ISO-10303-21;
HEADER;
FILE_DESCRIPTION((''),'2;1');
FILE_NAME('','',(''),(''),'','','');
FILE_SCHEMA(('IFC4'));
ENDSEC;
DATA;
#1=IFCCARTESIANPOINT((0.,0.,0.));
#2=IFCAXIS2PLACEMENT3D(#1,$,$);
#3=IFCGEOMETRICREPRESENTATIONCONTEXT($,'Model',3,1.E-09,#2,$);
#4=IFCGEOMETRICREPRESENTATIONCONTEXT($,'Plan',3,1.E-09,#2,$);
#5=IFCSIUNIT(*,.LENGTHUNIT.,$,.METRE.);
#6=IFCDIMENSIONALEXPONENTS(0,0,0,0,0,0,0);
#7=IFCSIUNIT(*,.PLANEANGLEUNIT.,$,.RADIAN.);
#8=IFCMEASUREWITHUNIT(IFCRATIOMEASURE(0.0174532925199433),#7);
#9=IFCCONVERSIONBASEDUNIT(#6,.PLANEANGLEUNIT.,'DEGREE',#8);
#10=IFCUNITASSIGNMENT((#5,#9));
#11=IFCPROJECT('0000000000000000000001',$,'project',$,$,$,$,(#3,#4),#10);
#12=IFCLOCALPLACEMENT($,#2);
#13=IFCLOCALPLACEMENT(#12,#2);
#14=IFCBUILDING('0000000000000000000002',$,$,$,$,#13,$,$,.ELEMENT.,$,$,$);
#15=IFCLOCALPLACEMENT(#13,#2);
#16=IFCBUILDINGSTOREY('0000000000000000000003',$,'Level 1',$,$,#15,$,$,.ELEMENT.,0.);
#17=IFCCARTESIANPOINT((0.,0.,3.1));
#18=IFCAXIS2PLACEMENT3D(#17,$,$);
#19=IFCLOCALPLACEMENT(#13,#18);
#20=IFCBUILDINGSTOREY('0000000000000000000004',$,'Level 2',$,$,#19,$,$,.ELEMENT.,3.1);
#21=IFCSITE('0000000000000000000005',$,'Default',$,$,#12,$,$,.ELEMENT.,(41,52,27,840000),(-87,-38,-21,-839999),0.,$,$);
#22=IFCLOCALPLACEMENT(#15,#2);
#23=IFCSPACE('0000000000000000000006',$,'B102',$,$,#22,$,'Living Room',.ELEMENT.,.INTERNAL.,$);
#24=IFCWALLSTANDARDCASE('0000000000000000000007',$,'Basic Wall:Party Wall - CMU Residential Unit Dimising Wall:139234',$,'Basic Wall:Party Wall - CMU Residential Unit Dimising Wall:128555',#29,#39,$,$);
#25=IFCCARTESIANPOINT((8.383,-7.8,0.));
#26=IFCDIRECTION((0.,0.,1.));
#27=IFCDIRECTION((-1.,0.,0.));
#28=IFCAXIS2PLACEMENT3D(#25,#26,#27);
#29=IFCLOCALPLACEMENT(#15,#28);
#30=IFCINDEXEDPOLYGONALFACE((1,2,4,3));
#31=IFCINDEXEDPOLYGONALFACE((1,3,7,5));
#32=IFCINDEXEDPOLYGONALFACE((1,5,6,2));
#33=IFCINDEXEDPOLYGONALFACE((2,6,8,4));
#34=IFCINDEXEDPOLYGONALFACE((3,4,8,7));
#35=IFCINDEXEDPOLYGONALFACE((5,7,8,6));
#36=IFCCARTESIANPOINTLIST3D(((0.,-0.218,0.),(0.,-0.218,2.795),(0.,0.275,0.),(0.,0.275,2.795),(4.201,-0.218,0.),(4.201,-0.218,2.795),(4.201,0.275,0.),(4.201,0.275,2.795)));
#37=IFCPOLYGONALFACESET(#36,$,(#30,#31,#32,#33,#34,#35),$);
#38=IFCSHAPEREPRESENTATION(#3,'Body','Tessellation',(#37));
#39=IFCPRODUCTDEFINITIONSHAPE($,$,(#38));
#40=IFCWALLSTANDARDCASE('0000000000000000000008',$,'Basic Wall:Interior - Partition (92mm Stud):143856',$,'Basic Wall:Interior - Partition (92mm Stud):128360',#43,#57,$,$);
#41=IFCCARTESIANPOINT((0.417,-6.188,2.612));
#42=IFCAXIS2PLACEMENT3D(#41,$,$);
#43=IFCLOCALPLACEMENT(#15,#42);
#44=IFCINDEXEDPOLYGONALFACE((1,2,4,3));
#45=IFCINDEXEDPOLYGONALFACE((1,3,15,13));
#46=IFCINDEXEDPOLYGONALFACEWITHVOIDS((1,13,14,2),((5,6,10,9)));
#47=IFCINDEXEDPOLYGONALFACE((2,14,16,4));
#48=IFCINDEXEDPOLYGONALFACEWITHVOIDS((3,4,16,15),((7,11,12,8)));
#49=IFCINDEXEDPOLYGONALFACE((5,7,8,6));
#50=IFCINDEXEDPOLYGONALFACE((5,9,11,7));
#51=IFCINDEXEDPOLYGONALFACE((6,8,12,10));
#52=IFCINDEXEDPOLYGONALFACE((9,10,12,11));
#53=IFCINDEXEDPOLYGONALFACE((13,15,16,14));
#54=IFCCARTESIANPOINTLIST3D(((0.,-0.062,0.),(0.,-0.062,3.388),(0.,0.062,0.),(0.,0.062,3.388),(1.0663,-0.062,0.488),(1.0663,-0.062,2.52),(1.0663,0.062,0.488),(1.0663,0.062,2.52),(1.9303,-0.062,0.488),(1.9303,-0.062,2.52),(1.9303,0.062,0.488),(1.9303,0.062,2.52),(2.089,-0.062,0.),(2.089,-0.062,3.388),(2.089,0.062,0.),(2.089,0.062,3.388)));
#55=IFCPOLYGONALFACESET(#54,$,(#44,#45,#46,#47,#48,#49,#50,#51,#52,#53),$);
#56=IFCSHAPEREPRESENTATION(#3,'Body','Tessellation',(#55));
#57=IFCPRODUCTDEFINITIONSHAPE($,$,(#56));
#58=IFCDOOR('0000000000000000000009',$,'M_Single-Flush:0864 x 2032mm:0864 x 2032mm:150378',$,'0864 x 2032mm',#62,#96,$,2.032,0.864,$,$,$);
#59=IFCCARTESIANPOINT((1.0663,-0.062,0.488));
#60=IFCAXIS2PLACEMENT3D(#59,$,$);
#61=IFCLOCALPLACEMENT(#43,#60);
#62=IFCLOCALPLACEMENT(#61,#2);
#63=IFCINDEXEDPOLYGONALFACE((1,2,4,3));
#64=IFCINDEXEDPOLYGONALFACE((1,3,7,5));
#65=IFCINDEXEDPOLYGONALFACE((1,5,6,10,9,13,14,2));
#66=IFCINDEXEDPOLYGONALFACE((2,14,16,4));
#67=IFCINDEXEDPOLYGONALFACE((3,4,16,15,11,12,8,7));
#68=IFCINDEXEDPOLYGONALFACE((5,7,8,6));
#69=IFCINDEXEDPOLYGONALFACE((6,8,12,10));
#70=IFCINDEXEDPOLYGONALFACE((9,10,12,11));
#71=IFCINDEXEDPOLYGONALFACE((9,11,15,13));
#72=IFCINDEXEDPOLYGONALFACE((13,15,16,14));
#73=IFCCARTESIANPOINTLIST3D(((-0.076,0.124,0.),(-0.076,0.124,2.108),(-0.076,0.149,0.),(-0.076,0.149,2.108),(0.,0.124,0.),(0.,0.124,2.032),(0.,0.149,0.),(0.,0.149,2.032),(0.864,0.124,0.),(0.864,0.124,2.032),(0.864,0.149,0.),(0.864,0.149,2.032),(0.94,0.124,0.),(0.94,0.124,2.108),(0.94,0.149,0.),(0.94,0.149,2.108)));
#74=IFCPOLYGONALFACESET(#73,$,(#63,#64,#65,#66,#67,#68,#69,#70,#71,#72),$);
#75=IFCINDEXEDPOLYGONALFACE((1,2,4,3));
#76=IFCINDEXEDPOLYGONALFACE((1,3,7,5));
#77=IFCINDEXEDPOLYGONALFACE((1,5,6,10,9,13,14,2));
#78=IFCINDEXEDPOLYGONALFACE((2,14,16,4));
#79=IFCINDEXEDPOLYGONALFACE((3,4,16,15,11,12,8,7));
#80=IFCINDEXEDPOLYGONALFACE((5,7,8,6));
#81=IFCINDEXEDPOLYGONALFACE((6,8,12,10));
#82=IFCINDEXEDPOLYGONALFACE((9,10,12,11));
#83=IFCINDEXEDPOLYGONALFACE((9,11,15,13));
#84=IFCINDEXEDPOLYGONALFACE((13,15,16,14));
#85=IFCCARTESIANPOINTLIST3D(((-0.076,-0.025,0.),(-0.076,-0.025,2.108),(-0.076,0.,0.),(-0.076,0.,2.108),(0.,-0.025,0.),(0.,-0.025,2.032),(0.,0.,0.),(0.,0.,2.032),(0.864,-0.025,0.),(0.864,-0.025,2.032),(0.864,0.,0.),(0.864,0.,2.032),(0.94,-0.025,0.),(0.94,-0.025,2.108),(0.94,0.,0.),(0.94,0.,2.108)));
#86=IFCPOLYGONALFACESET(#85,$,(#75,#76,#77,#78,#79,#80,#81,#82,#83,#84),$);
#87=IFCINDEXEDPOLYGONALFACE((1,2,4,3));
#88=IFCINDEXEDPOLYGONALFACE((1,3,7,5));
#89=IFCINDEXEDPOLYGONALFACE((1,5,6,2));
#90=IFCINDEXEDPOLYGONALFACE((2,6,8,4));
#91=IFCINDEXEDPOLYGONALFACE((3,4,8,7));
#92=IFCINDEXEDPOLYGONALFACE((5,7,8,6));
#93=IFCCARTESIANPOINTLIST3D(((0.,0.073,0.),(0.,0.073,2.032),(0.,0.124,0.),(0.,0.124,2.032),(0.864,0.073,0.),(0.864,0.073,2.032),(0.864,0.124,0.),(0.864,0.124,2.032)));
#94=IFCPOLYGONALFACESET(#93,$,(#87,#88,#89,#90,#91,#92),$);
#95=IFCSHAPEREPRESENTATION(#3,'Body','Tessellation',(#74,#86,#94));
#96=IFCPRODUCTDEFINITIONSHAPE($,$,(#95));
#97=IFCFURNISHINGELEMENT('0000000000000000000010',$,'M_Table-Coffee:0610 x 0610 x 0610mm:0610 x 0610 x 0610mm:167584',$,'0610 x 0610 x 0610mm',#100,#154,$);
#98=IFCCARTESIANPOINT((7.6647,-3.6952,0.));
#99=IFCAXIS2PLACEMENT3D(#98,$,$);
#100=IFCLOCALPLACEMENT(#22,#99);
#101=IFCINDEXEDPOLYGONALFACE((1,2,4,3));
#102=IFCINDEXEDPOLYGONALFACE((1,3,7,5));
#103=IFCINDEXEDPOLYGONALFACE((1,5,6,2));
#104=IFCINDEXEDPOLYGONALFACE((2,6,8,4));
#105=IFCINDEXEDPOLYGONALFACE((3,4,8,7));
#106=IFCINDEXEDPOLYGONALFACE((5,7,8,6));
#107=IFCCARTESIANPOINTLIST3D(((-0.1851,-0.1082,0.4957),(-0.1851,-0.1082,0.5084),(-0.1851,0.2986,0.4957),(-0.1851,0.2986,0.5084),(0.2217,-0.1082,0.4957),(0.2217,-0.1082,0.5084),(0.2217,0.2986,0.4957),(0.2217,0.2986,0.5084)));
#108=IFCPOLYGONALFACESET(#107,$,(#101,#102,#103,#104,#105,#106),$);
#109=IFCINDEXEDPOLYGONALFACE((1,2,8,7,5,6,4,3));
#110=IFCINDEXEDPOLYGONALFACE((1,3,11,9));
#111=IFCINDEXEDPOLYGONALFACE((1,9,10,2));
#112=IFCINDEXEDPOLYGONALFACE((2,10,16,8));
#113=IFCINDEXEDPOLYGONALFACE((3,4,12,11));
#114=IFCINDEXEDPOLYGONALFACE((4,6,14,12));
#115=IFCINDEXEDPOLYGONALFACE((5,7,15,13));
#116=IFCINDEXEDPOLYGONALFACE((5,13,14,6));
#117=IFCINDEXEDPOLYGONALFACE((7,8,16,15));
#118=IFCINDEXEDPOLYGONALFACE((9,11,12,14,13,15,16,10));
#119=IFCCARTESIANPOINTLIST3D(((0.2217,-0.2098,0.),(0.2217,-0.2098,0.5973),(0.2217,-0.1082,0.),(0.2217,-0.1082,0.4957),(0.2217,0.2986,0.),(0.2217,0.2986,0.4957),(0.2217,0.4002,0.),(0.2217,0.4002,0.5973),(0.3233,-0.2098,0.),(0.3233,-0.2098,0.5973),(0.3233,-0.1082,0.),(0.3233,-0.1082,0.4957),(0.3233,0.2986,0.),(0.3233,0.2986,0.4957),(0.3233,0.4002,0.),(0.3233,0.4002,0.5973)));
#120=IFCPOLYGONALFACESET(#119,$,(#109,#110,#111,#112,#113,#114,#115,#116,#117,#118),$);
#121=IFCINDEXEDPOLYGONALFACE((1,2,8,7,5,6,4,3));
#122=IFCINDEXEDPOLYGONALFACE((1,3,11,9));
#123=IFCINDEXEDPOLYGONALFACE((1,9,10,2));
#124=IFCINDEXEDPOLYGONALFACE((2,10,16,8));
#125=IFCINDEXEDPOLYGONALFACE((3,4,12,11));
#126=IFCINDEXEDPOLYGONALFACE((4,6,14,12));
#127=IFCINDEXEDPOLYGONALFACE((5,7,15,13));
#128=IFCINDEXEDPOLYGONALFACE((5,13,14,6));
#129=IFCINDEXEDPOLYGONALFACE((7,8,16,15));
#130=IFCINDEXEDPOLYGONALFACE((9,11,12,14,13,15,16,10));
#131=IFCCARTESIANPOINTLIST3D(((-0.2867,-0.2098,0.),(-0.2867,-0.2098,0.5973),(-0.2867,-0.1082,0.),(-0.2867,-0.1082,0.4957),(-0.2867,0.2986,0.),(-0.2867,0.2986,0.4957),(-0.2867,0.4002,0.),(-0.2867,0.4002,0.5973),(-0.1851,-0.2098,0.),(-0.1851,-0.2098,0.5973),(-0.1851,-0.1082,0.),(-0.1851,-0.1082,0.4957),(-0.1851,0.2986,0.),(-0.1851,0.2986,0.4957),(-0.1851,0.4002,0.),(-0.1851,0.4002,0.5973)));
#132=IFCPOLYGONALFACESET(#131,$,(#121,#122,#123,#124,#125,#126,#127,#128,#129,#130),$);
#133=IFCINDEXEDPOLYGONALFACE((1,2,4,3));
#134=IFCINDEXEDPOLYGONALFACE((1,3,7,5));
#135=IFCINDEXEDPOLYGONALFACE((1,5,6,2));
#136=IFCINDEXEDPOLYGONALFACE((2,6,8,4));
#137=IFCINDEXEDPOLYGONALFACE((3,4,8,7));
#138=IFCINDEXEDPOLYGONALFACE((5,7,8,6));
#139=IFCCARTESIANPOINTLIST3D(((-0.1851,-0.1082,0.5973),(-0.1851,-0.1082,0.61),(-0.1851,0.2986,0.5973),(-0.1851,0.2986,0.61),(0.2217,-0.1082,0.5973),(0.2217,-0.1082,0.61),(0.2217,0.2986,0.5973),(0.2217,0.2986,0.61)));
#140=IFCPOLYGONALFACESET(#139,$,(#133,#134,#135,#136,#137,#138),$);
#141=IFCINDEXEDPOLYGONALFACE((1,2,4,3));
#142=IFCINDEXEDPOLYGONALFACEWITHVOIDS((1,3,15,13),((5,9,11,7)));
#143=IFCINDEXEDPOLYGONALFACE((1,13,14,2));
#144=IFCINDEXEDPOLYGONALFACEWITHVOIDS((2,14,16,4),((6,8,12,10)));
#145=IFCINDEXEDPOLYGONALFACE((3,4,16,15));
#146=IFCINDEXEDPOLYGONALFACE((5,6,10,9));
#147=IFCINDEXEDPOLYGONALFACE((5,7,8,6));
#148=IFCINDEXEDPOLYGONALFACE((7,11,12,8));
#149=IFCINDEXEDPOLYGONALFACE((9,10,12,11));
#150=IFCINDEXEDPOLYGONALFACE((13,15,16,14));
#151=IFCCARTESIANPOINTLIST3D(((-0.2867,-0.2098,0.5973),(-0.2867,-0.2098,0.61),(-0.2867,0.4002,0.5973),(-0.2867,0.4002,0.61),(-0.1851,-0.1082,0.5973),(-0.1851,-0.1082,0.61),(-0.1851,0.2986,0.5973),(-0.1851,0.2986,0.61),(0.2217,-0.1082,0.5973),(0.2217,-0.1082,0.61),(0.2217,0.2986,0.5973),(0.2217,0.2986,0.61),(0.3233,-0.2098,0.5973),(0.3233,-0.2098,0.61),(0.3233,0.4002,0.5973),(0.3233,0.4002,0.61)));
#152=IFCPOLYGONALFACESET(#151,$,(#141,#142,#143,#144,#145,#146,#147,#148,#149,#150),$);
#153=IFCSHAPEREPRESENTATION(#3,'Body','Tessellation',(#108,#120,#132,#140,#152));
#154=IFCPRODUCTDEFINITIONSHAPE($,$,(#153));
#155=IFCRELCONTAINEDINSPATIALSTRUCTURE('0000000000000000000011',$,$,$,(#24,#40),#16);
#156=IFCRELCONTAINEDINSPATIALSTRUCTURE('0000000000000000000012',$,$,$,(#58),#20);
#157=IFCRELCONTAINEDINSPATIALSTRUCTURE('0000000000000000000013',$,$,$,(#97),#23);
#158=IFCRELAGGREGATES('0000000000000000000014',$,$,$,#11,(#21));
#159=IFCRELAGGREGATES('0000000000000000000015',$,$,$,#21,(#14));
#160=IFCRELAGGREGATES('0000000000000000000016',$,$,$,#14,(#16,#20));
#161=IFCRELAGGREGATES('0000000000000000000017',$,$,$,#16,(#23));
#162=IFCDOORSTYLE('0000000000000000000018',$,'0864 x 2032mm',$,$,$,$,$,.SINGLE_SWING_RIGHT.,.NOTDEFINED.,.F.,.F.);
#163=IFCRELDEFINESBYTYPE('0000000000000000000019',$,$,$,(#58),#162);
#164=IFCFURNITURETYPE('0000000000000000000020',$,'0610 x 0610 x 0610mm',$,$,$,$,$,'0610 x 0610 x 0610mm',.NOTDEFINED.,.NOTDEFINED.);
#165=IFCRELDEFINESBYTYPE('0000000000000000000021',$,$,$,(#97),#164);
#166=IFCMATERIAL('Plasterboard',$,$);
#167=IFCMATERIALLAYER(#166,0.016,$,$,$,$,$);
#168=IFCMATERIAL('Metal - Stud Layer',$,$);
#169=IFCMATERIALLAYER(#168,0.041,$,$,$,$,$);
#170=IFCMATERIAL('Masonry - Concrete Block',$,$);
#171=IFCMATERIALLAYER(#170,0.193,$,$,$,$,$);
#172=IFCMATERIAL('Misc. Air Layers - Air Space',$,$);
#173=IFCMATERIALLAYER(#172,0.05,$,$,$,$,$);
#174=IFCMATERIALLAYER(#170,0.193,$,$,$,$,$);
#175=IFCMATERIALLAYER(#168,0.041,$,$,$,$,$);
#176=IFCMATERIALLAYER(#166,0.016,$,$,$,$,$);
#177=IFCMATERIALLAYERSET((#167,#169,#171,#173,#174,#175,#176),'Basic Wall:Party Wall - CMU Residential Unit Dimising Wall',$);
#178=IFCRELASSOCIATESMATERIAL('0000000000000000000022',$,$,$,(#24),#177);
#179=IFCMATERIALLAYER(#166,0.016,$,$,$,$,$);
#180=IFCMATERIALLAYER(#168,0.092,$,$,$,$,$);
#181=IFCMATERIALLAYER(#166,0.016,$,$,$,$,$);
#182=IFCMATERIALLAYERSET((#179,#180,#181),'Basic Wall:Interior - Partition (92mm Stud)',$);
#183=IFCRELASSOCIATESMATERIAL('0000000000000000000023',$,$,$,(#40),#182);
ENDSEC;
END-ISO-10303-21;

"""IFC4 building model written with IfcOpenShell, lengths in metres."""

from ifc_helpers import new_model, entity, si_unit, converted_unit, frame, frame_2d, origin, origin_2d_with_axis, place, context, project, spatial, polyline, rectangle, outline, extrude, clip, bounded_halfspace, source, transform, mapped, material, layer, layer_set, layer_usage, type_object, type_shapes, element, fill, save


model = new_model("IFC4")

# Units and contexts
model_context = context("Model", 3, precision=1e-09, world=origin())
plan_context = context("Plan", 3, precision=1e-09, world=origin())
ifc_project = project(units=[si_unit("LENGTHUNIT", "METRE"), converted_unit("PLANEANGLEUNIT", "DEGREE", entity("IfcRatioMeasure", 0.0174532925199433), si_unit("PLANEANGLEUNIT", "RADIAN"), dimensions=[0, 0, 0, 0, 0, 0, 0])], contexts=[model_context, plan_context])

# Site, building, storey
site_placement = place(None, origin())
site = spatial("IfcSite", under=ifc_project, at=site_placement, Name="Default", CompositionType="ELEMENT", RefLatitude=(41, 52, 27, 840000), RefLongitude=(-87, -38, -21, -839999), RefElevation=0.0)
building_placement = place(site_placement, origin())
building = spatial("IfcBuilding", under=site, at=building_placement, CompositionType="ELEMENT")
storey_1_placement = place(building_placement, origin())
storey_1 = spatial("IfcBuildingStorey", under=building, at=storey_1_placement, Name="Level 1", CompositionType="ELEMENT", Elevation=0.0)

# Wall
ifc_material_1 = material(Name="Metal - Stud Layer")
ifc_material_2 = material(Name="Plasterboard")
ifc_layer_1 = layer(ifc_material_2, 0.016)
ifc_layer_2 = layer(ifc_material_1, 0.041)
ifc_material_3 = material(Name="Masonry - Concrete Block")
ifc_layer_3 = layer(ifc_material_3, 0.193)
ifc_material_4 = material(Name="Misc. Air Layers - Air Space")
ifc_layer_4 = layer(ifc_material_4, 0.05)
ifc_layer_5 = layer(ifc_material_3, 0.193)
ifc_layer_6 = layer(ifc_material_1, 0.041)
ifc_layer_7 = layer(ifc_material_2, 0.016)
ifc_layer_set_1 = layer_set([ifc_layer_1, ifc_layer_2, ifc_layer_3, ifc_layer_4, ifc_layer_5, ifc_layer_6, ifc_layer_7], Name="Basic Wall:Party Wall - CMU Residential Unit Dimising Wall")
ifc_layer_usage_1 = layer_usage(ifc_layer_set_1, "AXIS2", "NEGATIVE", 0.275)
wall_1_placement = place(storey_1_placement, frame((8.383, -7.8, 0.0), z_axis=(0.0, 0.0, 1.0), x_axis=(-1.0, 0.0, 0.0)))
element("IfcWallStandardCase", 1, at=wall_1_placement, inside=storey_1, material=ifc_layer_usage_1, Name="Basic Wall:Party Wall - CMU Residential Unit Dimising Wall:139234", ObjectType="Basic Wall:Party Wall - CMU Residential Unit Dimising Wall:128555", context=model_context, shape_type="Clipping", body=[
    clip(clip(extrude(rectangle(XDim=4.201, YDim=0.55, at=frame_2d((2.1005, 0.0), x_axis=(-1.0, 0.0))), origin(), (0.0, 0.0, 1.0), 2.795), bounded_halfspace(frame((0.0, -0.218, 2.795), z_axis=(0.0, 1.0, 0.0), x_axis=(-1.0, 0.0, 0.0)), True, frame((0.0, -0.218, 2.795), z_axis=(0.0, 1.0, 0.0), x_axis=(-1.0, 0.0, 0.0)), polyline([(0.0, 0.0), (-3.708, 0.0), (-4.201, 0.0), (-4.201, -2.795), (0.0, -2.795), (0.0, 0.0)]))), bounded_halfspace(frame((4.201, 0.275, 0.0), z_axis=(-1.0, 0.0, 0.0), x_axis=(0.0, -1.0, 0.0)), True, frame((4.201, 0.275, 0.0), z_axis=(-1.0, 0.0, 0.0), x_axis=(0.0, -1.0, 0.0)), polyline([(0.0, 0.0), (0.493, 0.0), (0.493, 2.795), (0.0, 2.795), (0.0, 0.0)]))),
])

# Shared definitions
ifc_layer_8 = layer(ifc_material_2, 0.016)
ifc_layer_9 = layer(ifc_material_1, 0.092)
ifc_layer_10 = layer(ifc_material_2, 0.016)
ifc_layer_set_2 = layer_set([ifc_layer_8, ifc_layer_9, ifc_layer_10], Name="Basic Wall:Interior - Partition (92mm Stud)")

# Wall, opening
ifc_layer_usage_2 = layer_usage(ifc_layer_set_2, "AXIS2", "NEGATIVE", 0.062)
wall_2_placement = place(storey_1_placement, frame((0.417, -6.188, 2.612)))
wall_2 = element("IfcWallStandardCase", 2, at=wall_2_placement, inside=storey_1, material=ifc_layer_usage_2, Name="Basic Wall:Interior - Partition (92mm Stud):143856", ObjectType="Basic Wall:Interior - Partition (92mm Stud):128360", context=model_context, shape_type="SweptSolid", body=[
    extrude(rectangle(XDim=2.089, YDim=0.124, at=frame_2d((1.0445, 0.0), x_axis=(-1.0, 0.0))), origin(), (0.0, 0.0, 1.0), 3.388),
])
opening_1_placement = place(wall_2_placement, frame((1.0663, -0.062, 0.488)))
opening_1 = element("IfcOpeningElement", 3, at=opening_1_placement, cuts=wall_2, ObjectType="Opening", context=model_context, shape_type="SweptSolid", body=[
    extrude(rectangle(XDim=0.864, YDim=2.032, at=frame_2d((1.016, 0.432), x_axis=(0.0, 1.0))), frame((0.0, 0.0, 0.0), z_axis=(0.0, 1.0, 0.0), x_axis=(0.0, 0.0, 1.0)), (0.0, 0.0, 1.0), 0.124),
])

# Shared definitions
storey_2_placement = place(building_placement, frame((0.0, 0.0, 3.1)))
storey_2 = spatial("IfcBuildingStorey", under=building, at=storey_2_placement, Name="Level 2", CompositionType="ELEMENT", Elevation=3.1)

# Door
door_style_1 = type_object("IfcDoorStyle", Name="0864 x 2032mm", ConstructionType="NOTDEFINED", OperationType="SINGLE_SWING_RIGHT", ParameterTakesPrecedence=False, Sizeable=False)
shared_shape_1 = source(origin(), model_context, "Body", "SweptSolid", [
    extrude(outline(polyline([(-0.508, -1.073), (0.508, -1.073), (0.508, 1.035), (0.432, 1.035), (0.432, -0.997), (-0.432, -0.997), (-0.432, 1.035), (-0.508, 1.035), (-0.508, -1.073)])), frame((0.432, 0.124, 1.035), z_axis=(0.0, 1.0, 0.0), x_axis=(1.0, 0.0, 0.0)), (0.0, 0.0, 1.0), 0.025),
    extrude(outline(polyline([(-1.073, -0.508), (1.035, -0.508), (1.035, -0.432), (-0.997, -0.432), (-0.997, 0.432), (1.035, 0.432), (1.035, 0.508), (-1.073, 0.508), (-1.073, -0.508)])), frame((0.432, -0.025, 1.035), z_axis=(0.0, 1.0, 0.0), x_axis=(0.0, 0.0, -1.0)), (0.0, 0.0, 1.0), 0.025),
    extrude(rectangle(XDim=0.051, YDim=0.864, at=origin_2d_with_axis()), frame((0.432, 0.0985, 0.0), z_axis=(0.0, 0.0, 1.0), x_axis=(0.0, 1.0, 0.0)), (0.0, 0.0, 1.0), 2.032),
])
type_shapes(door_style_1, [shared_shape_1])
door_1_placement = place(opening_1_placement, origin())
door_1 = element("IfcDoor", 4, at=door_1_placement, inside=storey_2, type_object=door_style_1, Name="M_Single-Flush:0864 x 2032mm:0864 x 2032mm:150378", ObjectType="0864 x 2032mm", OverallHeight=2.032, OverallWidth=0.864, context=model_context, shape_type="MappedRepresentation", body=[
    mapped(shared_shape_1, transform((0.0, 0.0, 0.0), scale=1.0)),
])
fill(opening_1, door_1)

# Shared definitions
space_1_placement = place(storey_1_placement, origin())
space_1 = spatial("IfcSpace", under=storey_1, at=space_1_placement, Name="B102", LongName="Living Room", CompositionType="ELEMENT", PredefinedType="INTERNAL")

# Furnishing element
furniture_type_1 = type_object("IfcFurnitureType", Name="0610 x 0610 x 0610mm", ElementType="0610 x 0610 x 0610mm", AssemblyPlace="NOTDEFINED")
shared_shape_2 = source(origin(), model_context, "Body", "SweptSolid", [
    extrude(rectangle(XDim=0.4068, YDim=0.4068, at=origin_2d_with_axis()), frame((0.0183, 0.0952, 0.4957), z_axis=(0.0, 0.0, 1.0), x_axis=(-1.0, 0.0, 0.0)), (0.0, 0.0, 1.0), 0.0127),
    extrude(outline(polyline([(-0.2732, -0.305), (0.324, -0.305), (0.324, 0.305), (-0.2732, 0.305), (-0.2732, 0.2034), (0.2225, 0.2034), (0.2225, -0.2034), (-0.2732, -0.2034), (-0.2732, -0.305)])), frame((0.2217, 0.0952, 0.2732), z_axis=(1.0, 0.0, 0.0), x_axis=(0.0, 0.0, 1.0)), (0.0, 0.0, 1.0), 0.1016),
    extrude(outline(polyline([(-0.305, -0.3241), (0.305, -0.3241), (0.305, 0.2733), (0.2034, 0.2733), (0.2034, -0.2224), (-0.2034, -0.2224), (-0.2034, 0.2733), (-0.305, 0.2733), (-0.305, -0.3241)])), frame((-0.2867, 0.0952, 0.2733), z_axis=(1.0, 0.0, 0.0), x_axis=(0.0, -1.0, 0.0)), (0.0, 0.0, 1.0), 0.1016),
    extrude(rectangle(XDim=0.4068, YDim=0.4068, at=origin_2d_with_axis()), frame((0.0183, 0.0952, 0.5973), z_axis=(0.0, 0.0, 1.0), x_axis=(-1.0, 0.0, 0.0)), (0.0, 0.0, 1.0), 0.0127),
    extrude(outline(polyline([(-0.305, -0.305), (0.305, -0.305), (0.305, 0.305), (-0.305, 0.305), (-0.305, -0.305)]), holes=[polyline([(-0.2034, -0.2034), (-0.2034, 0.2034), (0.2034, 0.2034), (0.2034, -0.2034), (-0.2034, -0.2034)])]), frame((0.0183, 0.0952, 0.5973), z_axis=(0.0, 0.0, 1.0), x_axis=(-1.0, 0.0, 0.0)), (0.0, 0.0, 1.0), 0.0127),
])
type_shapes(furniture_type_1, [shared_shape_2])
for number, where, name in (
    (5, (7.6647, -3.6952, 0.0), "M_Table-Coffee:0610 x 0610 x 0610mm:0610 x 0610 x 0610mm:167584"),
):
    element("IfcFurnishingElement", number, at=place(space_1_placement, frame(where)), inside=space_1, type_object=furniture_type_1, Name=name, ObjectType="0610 x 0610 x 0610mm", context=model_context, shape_type="MappedRepresentation", body=[
        mapped(shared_shape_2, transform((0.0, 0.0, 0.0), scale=1.0)),
    ])

save(model, "model.ifc")
